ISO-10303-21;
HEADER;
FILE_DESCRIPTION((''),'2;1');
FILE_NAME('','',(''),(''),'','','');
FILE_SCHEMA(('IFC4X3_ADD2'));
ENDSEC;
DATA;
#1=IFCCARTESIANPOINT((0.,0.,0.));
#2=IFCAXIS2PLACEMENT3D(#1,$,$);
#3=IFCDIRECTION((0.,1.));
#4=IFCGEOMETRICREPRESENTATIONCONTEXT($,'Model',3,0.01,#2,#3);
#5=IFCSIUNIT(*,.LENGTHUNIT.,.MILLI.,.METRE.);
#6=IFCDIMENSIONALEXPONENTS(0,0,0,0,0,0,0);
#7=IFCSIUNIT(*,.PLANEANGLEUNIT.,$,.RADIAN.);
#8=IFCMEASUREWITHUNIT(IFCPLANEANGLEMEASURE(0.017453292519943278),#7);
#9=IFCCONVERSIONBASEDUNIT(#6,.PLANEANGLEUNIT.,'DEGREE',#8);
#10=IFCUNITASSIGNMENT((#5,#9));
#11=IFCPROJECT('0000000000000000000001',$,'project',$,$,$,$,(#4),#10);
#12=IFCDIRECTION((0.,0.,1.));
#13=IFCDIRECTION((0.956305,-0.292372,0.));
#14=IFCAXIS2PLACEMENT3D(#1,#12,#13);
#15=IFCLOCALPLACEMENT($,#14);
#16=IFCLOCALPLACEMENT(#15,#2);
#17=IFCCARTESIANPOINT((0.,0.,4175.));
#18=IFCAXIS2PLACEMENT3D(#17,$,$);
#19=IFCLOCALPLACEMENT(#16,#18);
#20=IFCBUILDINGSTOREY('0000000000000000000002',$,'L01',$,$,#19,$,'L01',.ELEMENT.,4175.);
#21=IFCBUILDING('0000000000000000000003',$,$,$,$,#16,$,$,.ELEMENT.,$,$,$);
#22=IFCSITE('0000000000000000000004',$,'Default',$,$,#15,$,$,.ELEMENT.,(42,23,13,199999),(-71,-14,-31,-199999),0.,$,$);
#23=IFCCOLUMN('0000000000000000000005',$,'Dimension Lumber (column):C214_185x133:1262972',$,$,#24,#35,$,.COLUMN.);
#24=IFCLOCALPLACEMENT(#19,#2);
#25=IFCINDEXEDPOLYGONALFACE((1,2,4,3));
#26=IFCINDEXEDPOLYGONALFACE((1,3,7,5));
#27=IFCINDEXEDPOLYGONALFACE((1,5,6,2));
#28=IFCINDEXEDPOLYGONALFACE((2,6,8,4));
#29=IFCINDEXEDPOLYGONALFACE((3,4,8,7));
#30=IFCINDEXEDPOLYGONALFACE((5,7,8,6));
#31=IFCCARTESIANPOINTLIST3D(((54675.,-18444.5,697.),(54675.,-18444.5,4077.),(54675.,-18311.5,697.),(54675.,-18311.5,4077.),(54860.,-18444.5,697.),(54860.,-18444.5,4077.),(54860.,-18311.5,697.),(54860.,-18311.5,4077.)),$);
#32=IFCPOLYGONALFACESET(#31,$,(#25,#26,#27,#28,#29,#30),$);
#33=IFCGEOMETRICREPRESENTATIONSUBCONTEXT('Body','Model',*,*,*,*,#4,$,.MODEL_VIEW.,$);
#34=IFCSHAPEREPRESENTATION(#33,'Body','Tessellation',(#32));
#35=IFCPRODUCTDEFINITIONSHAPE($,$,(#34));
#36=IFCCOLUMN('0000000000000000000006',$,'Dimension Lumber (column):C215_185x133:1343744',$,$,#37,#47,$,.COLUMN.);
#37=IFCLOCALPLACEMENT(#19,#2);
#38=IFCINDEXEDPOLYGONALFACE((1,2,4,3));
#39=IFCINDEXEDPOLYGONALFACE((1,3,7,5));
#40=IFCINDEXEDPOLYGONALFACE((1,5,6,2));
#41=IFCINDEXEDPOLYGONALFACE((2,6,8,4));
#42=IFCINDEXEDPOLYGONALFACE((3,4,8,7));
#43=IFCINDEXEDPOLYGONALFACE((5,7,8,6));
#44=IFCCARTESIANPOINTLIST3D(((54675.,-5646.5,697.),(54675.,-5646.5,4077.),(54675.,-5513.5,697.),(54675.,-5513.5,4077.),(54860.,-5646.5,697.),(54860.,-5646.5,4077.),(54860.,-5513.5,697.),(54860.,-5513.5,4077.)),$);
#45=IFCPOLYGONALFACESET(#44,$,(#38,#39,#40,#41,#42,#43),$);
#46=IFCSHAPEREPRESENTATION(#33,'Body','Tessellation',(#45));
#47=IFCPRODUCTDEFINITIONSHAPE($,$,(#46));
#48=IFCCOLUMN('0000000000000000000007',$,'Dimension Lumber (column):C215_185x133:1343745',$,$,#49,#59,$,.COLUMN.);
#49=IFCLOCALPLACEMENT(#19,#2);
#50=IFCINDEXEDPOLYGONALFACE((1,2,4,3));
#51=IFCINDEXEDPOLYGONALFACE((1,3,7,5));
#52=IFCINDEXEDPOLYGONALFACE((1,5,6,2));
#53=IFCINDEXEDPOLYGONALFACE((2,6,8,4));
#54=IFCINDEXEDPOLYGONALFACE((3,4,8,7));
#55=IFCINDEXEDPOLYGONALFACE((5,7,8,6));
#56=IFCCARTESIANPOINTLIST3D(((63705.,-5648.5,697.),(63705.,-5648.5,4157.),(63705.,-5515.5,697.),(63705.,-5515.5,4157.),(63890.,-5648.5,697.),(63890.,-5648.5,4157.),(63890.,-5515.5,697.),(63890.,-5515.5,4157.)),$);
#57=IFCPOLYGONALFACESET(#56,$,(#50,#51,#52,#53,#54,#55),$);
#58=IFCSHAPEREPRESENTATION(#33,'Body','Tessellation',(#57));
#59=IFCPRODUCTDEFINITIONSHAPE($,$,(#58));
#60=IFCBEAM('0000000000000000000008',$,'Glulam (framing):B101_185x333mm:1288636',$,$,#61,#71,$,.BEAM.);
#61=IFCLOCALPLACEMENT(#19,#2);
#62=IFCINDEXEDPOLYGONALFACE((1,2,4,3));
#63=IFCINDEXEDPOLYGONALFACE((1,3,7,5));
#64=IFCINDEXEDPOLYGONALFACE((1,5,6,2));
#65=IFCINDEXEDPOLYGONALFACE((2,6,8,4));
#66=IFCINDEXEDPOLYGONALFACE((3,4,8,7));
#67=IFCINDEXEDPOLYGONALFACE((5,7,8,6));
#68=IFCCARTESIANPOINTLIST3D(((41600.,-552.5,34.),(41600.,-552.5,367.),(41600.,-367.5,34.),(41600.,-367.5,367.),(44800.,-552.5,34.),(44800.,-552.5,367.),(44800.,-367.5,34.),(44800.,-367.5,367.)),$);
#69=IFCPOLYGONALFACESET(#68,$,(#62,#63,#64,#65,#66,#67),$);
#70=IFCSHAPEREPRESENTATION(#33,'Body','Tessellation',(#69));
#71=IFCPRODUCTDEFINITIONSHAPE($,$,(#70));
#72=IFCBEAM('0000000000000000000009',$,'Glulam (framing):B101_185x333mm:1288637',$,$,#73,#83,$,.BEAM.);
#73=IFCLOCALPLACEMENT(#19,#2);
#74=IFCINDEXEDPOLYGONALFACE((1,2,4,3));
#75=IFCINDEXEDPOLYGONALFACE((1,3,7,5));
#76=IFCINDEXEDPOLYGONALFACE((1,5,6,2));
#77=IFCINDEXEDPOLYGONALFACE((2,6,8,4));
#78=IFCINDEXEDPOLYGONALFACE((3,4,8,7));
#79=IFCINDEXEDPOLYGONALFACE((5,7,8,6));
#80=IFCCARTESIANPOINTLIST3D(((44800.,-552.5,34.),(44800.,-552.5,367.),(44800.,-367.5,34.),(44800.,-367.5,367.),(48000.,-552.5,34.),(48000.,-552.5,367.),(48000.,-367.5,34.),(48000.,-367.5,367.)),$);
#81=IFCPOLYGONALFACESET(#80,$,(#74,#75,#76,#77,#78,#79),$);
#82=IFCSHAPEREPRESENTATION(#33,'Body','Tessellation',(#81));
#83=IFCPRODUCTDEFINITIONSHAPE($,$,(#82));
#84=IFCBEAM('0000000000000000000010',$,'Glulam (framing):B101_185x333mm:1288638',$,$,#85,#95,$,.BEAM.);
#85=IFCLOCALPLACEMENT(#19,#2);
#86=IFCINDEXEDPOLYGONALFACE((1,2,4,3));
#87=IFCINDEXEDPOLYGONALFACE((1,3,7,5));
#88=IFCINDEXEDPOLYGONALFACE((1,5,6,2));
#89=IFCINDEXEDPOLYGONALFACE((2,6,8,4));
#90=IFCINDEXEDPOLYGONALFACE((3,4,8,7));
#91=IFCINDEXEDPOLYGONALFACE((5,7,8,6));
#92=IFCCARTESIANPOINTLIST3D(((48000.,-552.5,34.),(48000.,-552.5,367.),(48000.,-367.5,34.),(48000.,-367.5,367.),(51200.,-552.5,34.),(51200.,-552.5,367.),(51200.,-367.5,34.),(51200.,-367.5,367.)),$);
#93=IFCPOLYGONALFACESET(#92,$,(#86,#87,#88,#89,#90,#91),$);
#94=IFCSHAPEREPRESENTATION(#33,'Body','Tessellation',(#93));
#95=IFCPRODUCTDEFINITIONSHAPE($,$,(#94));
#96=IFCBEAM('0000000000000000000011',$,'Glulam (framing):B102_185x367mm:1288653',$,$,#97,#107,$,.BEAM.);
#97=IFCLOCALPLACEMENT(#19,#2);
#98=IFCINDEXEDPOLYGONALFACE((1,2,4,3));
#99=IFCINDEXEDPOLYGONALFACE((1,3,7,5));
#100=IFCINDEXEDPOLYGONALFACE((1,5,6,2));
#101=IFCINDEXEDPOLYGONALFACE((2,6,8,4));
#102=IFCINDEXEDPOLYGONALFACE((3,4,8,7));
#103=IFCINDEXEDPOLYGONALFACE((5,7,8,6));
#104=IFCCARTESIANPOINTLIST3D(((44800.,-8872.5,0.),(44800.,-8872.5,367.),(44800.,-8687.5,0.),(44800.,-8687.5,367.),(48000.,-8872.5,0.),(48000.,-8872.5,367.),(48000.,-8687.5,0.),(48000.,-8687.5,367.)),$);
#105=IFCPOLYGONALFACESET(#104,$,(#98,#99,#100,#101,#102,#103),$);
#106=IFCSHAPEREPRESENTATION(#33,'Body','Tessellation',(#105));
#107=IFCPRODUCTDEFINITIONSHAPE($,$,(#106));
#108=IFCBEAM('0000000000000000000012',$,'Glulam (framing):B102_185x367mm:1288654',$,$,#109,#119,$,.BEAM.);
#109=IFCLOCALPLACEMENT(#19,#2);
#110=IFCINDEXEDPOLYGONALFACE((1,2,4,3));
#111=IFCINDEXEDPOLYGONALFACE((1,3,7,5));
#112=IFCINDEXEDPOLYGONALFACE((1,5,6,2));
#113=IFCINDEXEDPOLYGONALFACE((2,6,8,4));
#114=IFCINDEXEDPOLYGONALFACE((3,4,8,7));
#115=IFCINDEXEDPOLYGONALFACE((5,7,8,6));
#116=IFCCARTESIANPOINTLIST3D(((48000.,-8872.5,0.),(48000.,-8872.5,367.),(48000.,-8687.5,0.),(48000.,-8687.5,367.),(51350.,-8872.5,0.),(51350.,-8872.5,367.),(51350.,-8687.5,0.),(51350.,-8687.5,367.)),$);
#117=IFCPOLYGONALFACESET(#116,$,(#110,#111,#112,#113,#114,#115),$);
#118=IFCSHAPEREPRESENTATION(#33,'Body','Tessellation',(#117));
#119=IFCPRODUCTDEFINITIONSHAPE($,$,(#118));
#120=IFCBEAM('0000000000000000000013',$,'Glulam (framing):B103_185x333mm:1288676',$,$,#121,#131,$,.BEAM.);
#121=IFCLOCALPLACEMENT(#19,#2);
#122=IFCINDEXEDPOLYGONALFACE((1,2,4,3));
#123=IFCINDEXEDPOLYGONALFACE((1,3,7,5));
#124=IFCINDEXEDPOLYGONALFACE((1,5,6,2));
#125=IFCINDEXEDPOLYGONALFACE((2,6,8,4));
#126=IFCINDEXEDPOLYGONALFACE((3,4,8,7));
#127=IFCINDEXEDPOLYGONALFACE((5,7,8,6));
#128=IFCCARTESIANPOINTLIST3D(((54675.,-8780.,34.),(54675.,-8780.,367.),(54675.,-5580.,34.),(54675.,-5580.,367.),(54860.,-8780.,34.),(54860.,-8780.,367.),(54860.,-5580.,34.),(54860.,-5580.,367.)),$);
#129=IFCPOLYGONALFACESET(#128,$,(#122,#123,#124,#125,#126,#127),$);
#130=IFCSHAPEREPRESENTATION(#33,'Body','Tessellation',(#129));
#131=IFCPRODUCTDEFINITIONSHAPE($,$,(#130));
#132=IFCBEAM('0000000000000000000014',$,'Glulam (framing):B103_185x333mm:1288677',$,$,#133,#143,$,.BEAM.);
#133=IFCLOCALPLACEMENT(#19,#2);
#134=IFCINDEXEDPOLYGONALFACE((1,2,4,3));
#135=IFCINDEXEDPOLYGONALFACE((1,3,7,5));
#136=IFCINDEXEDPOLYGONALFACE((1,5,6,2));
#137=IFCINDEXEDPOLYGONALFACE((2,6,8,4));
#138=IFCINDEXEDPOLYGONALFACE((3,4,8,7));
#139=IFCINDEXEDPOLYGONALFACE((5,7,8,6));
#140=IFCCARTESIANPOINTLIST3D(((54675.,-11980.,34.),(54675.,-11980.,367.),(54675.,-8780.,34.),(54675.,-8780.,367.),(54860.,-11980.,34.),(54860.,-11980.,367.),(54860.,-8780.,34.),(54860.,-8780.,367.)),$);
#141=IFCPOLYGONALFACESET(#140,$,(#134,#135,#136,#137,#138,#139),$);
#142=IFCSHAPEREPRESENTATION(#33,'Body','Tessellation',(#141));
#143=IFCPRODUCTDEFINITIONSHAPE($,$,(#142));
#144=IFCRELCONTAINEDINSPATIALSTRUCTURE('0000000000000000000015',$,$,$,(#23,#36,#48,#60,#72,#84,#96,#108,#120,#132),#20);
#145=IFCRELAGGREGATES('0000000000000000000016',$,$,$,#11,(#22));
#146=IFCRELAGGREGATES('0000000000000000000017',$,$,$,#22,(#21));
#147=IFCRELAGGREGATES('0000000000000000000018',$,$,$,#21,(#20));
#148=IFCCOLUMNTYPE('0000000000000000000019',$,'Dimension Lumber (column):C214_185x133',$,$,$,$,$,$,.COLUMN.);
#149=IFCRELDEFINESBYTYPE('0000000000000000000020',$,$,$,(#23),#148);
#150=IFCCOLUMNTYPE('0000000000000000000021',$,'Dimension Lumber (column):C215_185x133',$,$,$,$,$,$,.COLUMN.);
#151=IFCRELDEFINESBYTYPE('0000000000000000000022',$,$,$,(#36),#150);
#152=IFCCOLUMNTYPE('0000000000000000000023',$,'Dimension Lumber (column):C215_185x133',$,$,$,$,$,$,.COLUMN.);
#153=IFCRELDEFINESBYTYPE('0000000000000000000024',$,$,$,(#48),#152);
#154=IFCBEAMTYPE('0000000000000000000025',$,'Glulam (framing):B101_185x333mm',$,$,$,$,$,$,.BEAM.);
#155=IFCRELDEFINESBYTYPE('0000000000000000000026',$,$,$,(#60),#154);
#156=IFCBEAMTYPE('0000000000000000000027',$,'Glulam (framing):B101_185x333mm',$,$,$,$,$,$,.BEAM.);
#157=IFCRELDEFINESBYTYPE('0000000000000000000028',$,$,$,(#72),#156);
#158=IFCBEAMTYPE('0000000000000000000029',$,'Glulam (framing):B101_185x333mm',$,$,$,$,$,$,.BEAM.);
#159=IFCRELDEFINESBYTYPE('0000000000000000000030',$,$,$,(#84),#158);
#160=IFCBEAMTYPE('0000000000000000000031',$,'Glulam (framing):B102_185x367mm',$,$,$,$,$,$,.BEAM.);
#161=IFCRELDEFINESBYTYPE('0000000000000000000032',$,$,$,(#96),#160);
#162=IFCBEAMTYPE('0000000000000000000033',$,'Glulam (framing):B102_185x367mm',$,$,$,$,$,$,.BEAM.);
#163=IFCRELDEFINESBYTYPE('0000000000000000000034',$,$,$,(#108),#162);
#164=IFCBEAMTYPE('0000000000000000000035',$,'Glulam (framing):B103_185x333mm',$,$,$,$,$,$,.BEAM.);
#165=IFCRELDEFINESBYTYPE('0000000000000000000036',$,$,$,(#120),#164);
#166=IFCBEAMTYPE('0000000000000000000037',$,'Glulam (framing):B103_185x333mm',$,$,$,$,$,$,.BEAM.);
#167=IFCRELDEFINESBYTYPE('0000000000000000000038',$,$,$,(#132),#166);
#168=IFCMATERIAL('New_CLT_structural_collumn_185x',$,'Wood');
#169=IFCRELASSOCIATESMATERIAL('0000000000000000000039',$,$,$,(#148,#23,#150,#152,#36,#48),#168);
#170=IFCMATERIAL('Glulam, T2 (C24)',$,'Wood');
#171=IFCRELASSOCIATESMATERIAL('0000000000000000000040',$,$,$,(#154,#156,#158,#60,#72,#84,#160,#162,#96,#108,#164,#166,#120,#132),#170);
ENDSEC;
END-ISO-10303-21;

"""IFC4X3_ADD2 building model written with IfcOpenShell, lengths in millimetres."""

from ifc_helpers import new_model, entity, si_unit, converted_unit, direction, frame, origin, origin_2d_with_axis, place, context, subcontext, project, spatial, rectangle, extrude, source, transform, mapped, material, material_profile, profile_set, profile_usage, type_object, type_shapes, element, save


model = new_model("IFC4X3_ADD2")

# Units and contexts
model_context = context("Model", 3, precision=0.01, world=origin(), true_north=direction((0.0, 1.0)))
body_context = subcontext(model_context, "Body", "Model", "MODEL_VIEW")
ifc_project = project(units=[si_unit("LENGTHUNIT", "METRE", prefix="MILLI"), converted_unit("PLANEANGLEUNIT", "DEGREE", entity("IfcPlaneAngleMeasure", 0.017453292519943278), si_unit("PLANEANGLEUNIT", "RADIAN"), dimensions=[0, 0, 0, 0, 0, 0, 0])], contexts=[model_context])

# Site, building, storey
site_placement = place(None, frame((0.0, 0.0, 0.0), z_axis=(0.0, 0.0, 1.0), x_axis=(0.956305, -0.292372, 0.0)))
site = spatial("IfcSite", under=ifc_project, at=site_placement, Name="Default", CompositionType="ELEMENT", RefLatitude=(42, 23, 13, 199999), RefLongitude=(-71, -14, -31, -199999), RefElevation=0.0)
building_placement = place(site_placement, origin())
building = spatial("IfcBuilding", under=site, at=building_placement, CompositionType="ELEMENT")
storey_placement = place(building_placement, frame((0.0, 0.0, 4175.0)))
storey = spatial("IfcBuildingStorey", under=building, at=storey_placement, Name="L01", LongName="L01", CompositionType="ELEMENT", Elevation=4175.0)

# Columns
ifc_material_1 = material(Name="New_CLT_structural_collumn_185x", Category="Wood")
ifc_material_profile_1 = material_profile(ifc_material_1, rectangle(XDim=185.0, YDim=133.0, at=origin_2d_with_axis()), Name="C214_185x133")
ifc_profile_set_1 = profile_set([ifc_material_profile_1], Name="C214_185x133")
ifc_profile_usage_1 = profile_usage(ifc_profile_set_1)
column_type_1 = type_object("IfcColumnType", Name="Dimension Lumber (column):C214_185x133", PredefinedType="COLUMN", material=ifc_profile_set_1)
shared_shape_1 = source(origin(), body_context, "Body", "SweptSolid", [
    extrude(rectangle(XDim=185.0, YDim=133.0, at=origin_2d_with_axis()), frame((0.0, 0.0, 4872.0), z_axis=(0.0, 0.0, 1.0), x_axis=(-1.0, 0.0, 0.0)), (0.0, 0.0, 1.0), 3380.0),
])
type_shapes(column_type_1, [shared_shape_1])
for number, where, name in (
    (1, (54767.5, -18378.0, -4175.0), "Dimension Lumber (column):C214_185x133:1262972"),
):
    element("IfcColumn", number, at=place(storey_placement, frame(where)), inside=storey, type_object=column_type_1, material=ifc_profile_usage_1, Name=name, PredefinedType="COLUMN", context=body_context, shape_type="MappedRepresentation", body=[
        mapped(shared_shape_1, transform((0.0, 0.0, 0.0), scale=1.0)),
    ])
ifc_material_profile_2 = material_profile(ifc_material_1, rectangle(XDim=185.0, YDim=133.0, at=origin_2d_with_axis()), Name="C215_185x133")
ifc_profile_set_2 = profile_set([ifc_material_profile_2], Name="C215_185x133")
ifc_profile_usage_2 = profile_usage(ifc_profile_set_2)
column_type_2 = type_object("IfcColumnType", Name="Dimension Lumber (column):C215_185x133", PredefinedType="COLUMN", material=ifc_profile_set_2)
shared_shape_2 = source(origin(), body_context, "Body", "SweptSolid", [
    extrude(rectangle(XDim=185.0, YDim=133.0, at=origin_2d_with_axis()), frame((0.0, 0.0, 4872.0), z_axis=(0.0, 0.0, 1.0), x_axis=(-1.0, 0.0, 0.0)), (0.0, 0.0, 1.0), 3380.0),
])
type_shapes(column_type_2, [shared_shape_2])
column_1_placement = place(storey_placement, frame((54767.5, -5580.0, -4175.0), z_axis=(0.0, 0.0, 1.0), x_axis=(-1.0, 0.0, 0.0)))
element("IfcColumn", 2, at=column_1_placement, inside=storey, type_object=column_type_2, material=ifc_profile_usage_2, Name="Dimension Lumber (column):C215_185x133:1343744", PredefinedType="COLUMN", context=body_context, shape_type="MappedRepresentation", body=[
    mapped(shared_shape_2, transform((0.0, 0.0, 0.0), scale=1.0)),
])
column_type_3 = type_object("IfcColumnType", Name="Dimension Lumber (column):C215_185x133", PredefinedType="COLUMN", material=ifc_profile_set_2)
shared_shape_3 = source(origin(), body_context, "Body", "SweptSolid", [
    extrude(rectangle(XDim=185.0, YDim=133.0, at=origin_2d_with_axis()), frame((0.0, 0.0, 4872.0), z_axis=(0.0, 0.0, 1.0), x_axis=(-1.0, 0.0, 0.0)), (0.0, 0.0, 1.0), 3460.0),
])
type_shapes(column_type_3, [shared_shape_3])
column_2_placement = place(storey_placement, frame((63797.5, -5582.0, -4175.0)))
element("IfcColumn", 3, at=column_2_placement, inside=storey, type_object=column_type_3, material=ifc_profile_usage_2, Name="Dimension Lumber (column):C215_185x133:1343745", PredefinedType="COLUMN", context=body_context, shape_type="MappedRepresentation", body=[
    mapped(shared_shape_3, transform((0.0, 0.0, 0.0), scale=1.0)),
])

# Beams
ifc_material_2 = material(Name="Glulam, T2 (C24)", Category="Wood")
ifc_material_profile_3 = material_profile(ifc_material_2, rectangle(XDim=3520.0, YDim=185.0, at=origin_2d_with_axis()), Name="B101_185x333mm")
ifc_profile_set_3 = profile_set([ifc_material_profile_3], Name="B101_185x333mm")
ifc_profile_usage_3 = profile_usage(ifc_profile_set_3, cardinal=8)
beam_type_1 = type_object("IfcBeamType", Name="Glulam (framing):B101_185x333mm", PredefinedType="BEAM", material=ifc_profile_set_3)
shared_shape_4 = source(origin(), body_context, "Body", "SweptSolid", [
    extrude(rectangle(XDim=3200.0, YDim=185.0, at=origin_2d_with_axis()), frame((0.0, 0.0, -166.5), z_axis=(0.0, 0.0, 1.0), x_axis=(-1.0, 0.0, 0.0)), (0.0, 0.0, 1.0), 333.0),
])
type_shapes(beam_type_1, [shared_shape_4])
beam_1_placement = place(storey_placement, frame((43200.0, -460.0, 200.5), z_axis=(0.0, 0.0, 1.0), x_axis=(-1.0, 0.0, 0.0)))
element("IfcBeam", 4, at=beam_1_placement, inside=storey, type_object=beam_type_1, material=ifc_profile_usage_3, Name="Glulam (framing):B101_185x333mm:1288636", PredefinedType="BEAM", context=body_context, shape_type="MappedRepresentation", body=[
    mapped(shared_shape_4, transform((0.0, 0.0, 0.0), scale=1.0)),
])
beam_type_2 = type_object("IfcBeamType", Name="Glulam (framing):B101_185x333mm", PredefinedType="BEAM", material=ifc_profile_set_3)
shared_shape_5 = source(origin(), body_context, "Body", "SweptSolid", [
    extrude(rectangle(XDim=3200.0, YDim=185.0, at=origin_2d_with_axis()), frame((0.0, 0.0, -166.5), z_axis=(0.0, 0.0, 1.0), x_axis=(-1.0, 0.0, 0.0)), (0.0, 0.0, 1.0), 333.0),
])
type_shapes(beam_type_2, [shared_shape_5])
beam_2_placement = place(storey_placement, frame((46400.0, -460.0, 200.5), z_axis=(0.0, 0.0, 1.0), x_axis=(-1.0, 0.0, 0.0)))
element("IfcBeam", 5, at=beam_2_placement, inside=storey, type_object=beam_type_2, material=ifc_profile_usage_3, Name="Glulam (framing):B101_185x333mm:1288637", PredefinedType="BEAM", context=body_context, shape_type="MappedRepresentation", body=[
    mapped(shared_shape_5, transform((0.0, 0.0, 0.0), scale=1.0)),
])
beam_type_3 = type_object("IfcBeamType", Name="Glulam (framing):B101_185x333mm", PredefinedType="BEAM", material=ifc_profile_set_3)
shared_shape_6 = source(origin(), body_context, "Body", "SweptSolid", [
    extrude(rectangle(XDim=3200.0, YDim=185.0, at=origin_2d_with_axis()), frame((0.0, 0.0, -166.5), z_axis=(0.0, 0.0, 1.0), x_axis=(-1.0, 0.0, 0.0)), (0.0, 0.0, 1.0), 333.0),
])
type_shapes(beam_type_3, [shared_shape_6])
beam_3_placement = place(storey_placement, frame((49600.0, -460.0, 200.5), z_axis=(0.0, 0.0, 1.0), x_axis=(-1.0, 0.0, 0.0)))
element("IfcBeam", 6, at=beam_3_placement, inside=storey, type_object=beam_type_3, material=ifc_profile_usage_3, Name="Glulam (framing):B101_185x333mm:1288638", PredefinedType="BEAM", context=body_context, shape_type="MappedRepresentation", body=[
    mapped(shared_shape_6, transform((0.0, 0.0, 0.0), scale=1.0)),
])
ifc_material_profile_4 = material_profile(ifc_material_2, rectangle(XDim=3350.0, YDim=185.0, at=origin_2d_with_axis()), Name="B102_185x367mm")
ifc_profile_set_4 = profile_set([ifc_material_profile_4], Name="B102_185x367mm")
ifc_profile_usage_4 = profile_usage(ifc_profile_set_4, cardinal=8)
beam_type_4 = type_object("IfcBeamType", Name="Glulam (framing):B102_185x367mm", PredefinedType="BEAM", material=ifc_profile_set_4)
shared_shape_7 = source(origin(), body_context, "Body", "SweptSolid", [
    extrude(rectangle(XDim=3200.0, YDim=185.0, at=origin_2d_with_axis()), frame((0.0, 0.0, -183.5), z_axis=(0.0, 0.0, 1.0), x_axis=(-1.0, 0.0, 0.0)), (0.0, 0.0, 1.0), 367.0),
])
type_shapes(beam_type_4, [shared_shape_7])
beam_4_placement = place(storey_placement, frame((46400.0, -8780.0, 183.5)))
element("IfcBeam", 7, at=beam_4_placement, inside=storey, type_object=beam_type_4, material=ifc_profile_usage_4, Name="Glulam (framing):B102_185x367mm:1288653", PredefinedType="BEAM", context=body_context, shape_type="MappedRepresentation", body=[
    mapped(shared_shape_7, transform((0.0, 0.0, 0.0), scale=1.0)),
])
beam_type_5 = type_object("IfcBeamType", Name="Glulam (framing):B102_185x367mm", PredefinedType="BEAM", material=ifc_profile_set_4)
shared_shape_8 = source(origin(), body_context, "Body", "SweptSolid", [
    extrude(rectangle(XDim=3350.0, YDim=185.0, at=origin_2d_with_axis()), frame((75.0, 0.0, -183.5), z_axis=(0.0, 0.0, 1.0), x_axis=(-1.0, 0.0, 0.0)), (0.0, 0.0, 1.0), 367.0),
])
type_shapes(beam_type_5, [shared_shape_8])
beam_5_placement = place(storey_placement, frame((49600.0, -8780.0, 183.5)))
element("IfcBeam", 8, at=beam_5_placement, inside=storey, type_object=beam_type_5, material=ifc_profile_usage_4, Name="Glulam (framing):B102_185x367mm:1288654", PredefinedType="BEAM", context=body_context, shape_type="MappedRepresentation", body=[
    mapped(shared_shape_8, transform((0.0, 0.0, 0.0), scale=1.0)),
])
ifc_material_profile_5 = material_profile(ifc_material_2, rectangle(XDim=3200.0, YDim=185.0, at=origin_2d_with_axis()), Name="B103_185x333mm")
ifc_profile_set_5 = profile_set([ifc_material_profile_5], Name="B103_185x333mm")
ifc_profile_usage_5 = profile_usage(ifc_profile_set_5, cardinal=8)
beam_type_6 = type_object("IfcBeamType", Name="Glulam (framing):B103_185x333mm", PredefinedType="BEAM", material=ifc_profile_set_5)
shared_shape_9 = source(origin(), body_context, "Body", "SweptSolid", [
    extrude(rectangle(XDim=3200.0, YDim=185.0, at=origin_2d_with_axis()), frame((0.0, 0.0, -166.5), z_axis=(0.0, 0.0, 1.0), x_axis=(-1.0, 0.0, 0.0)), (0.0, 0.0, 1.0), 333.0),
])
type_shapes(beam_type_6, [shared_shape_9])
beam_6_placement = place(storey_placement, frame((54767.5, -7180.0, 200.5), z_axis=(0.0, 0.0, 1.0), x_axis=(0.0, -1.0, 0.0)))
element("IfcBeam", 9, at=beam_6_placement, inside=storey, type_object=beam_type_6, material=ifc_profile_usage_5, Name="Glulam (framing):B103_185x333mm:1288676", PredefinedType="BEAM", context=body_context, shape_type="MappedRepresentation", body=[
    mapped(shared_shape_9, transform((0.0, 0.0, 0.0), scale=1.0)),
])
beam_type_7 = type_object("IfcBeamType", Name="Glulam (framing):B103_185x333mm", PredefinedType="BEAM", material=ifc_profile_set_5)
shared_shape_10 = source(origin(), body_context, "Body", "SweptSolid", [
    extrude(rectangle(XDim=3200.0, YDim=185.0, at=origin_2d_with_axis()), frame((0.0, 0.0, -166.5), z_axis=(0.0, 0.0, 1.0), x_axis=(-1.0, 0.0, 0.0)), (0.0, 0.0, 1.0), 333.0),
])
type_shapes(beam_type_7, [shared_shape_10])
beam_7_placement = place(storey_placement, frame((54767.5, -10380.0, 200.5), z_axis=(0.0, 0.0, 1.0), x_axis=(0.0, -1.0, 0.0)))
element("IfcBeam", 10, at=beam_7_placement, inside=storey, type_object=beam_type_7, material=ifc_profile_usage_5, Name="Glulam (framing):B103_185x333mm:1288677", PredefinedType="BEAM", context=body_context, shape_type="MappedRepresentation", body=[
    mapped(shared_shape_10, transform((0.0, 0.0, 0.0), scale=1.0)),
])

save(model, "model.ifc")
